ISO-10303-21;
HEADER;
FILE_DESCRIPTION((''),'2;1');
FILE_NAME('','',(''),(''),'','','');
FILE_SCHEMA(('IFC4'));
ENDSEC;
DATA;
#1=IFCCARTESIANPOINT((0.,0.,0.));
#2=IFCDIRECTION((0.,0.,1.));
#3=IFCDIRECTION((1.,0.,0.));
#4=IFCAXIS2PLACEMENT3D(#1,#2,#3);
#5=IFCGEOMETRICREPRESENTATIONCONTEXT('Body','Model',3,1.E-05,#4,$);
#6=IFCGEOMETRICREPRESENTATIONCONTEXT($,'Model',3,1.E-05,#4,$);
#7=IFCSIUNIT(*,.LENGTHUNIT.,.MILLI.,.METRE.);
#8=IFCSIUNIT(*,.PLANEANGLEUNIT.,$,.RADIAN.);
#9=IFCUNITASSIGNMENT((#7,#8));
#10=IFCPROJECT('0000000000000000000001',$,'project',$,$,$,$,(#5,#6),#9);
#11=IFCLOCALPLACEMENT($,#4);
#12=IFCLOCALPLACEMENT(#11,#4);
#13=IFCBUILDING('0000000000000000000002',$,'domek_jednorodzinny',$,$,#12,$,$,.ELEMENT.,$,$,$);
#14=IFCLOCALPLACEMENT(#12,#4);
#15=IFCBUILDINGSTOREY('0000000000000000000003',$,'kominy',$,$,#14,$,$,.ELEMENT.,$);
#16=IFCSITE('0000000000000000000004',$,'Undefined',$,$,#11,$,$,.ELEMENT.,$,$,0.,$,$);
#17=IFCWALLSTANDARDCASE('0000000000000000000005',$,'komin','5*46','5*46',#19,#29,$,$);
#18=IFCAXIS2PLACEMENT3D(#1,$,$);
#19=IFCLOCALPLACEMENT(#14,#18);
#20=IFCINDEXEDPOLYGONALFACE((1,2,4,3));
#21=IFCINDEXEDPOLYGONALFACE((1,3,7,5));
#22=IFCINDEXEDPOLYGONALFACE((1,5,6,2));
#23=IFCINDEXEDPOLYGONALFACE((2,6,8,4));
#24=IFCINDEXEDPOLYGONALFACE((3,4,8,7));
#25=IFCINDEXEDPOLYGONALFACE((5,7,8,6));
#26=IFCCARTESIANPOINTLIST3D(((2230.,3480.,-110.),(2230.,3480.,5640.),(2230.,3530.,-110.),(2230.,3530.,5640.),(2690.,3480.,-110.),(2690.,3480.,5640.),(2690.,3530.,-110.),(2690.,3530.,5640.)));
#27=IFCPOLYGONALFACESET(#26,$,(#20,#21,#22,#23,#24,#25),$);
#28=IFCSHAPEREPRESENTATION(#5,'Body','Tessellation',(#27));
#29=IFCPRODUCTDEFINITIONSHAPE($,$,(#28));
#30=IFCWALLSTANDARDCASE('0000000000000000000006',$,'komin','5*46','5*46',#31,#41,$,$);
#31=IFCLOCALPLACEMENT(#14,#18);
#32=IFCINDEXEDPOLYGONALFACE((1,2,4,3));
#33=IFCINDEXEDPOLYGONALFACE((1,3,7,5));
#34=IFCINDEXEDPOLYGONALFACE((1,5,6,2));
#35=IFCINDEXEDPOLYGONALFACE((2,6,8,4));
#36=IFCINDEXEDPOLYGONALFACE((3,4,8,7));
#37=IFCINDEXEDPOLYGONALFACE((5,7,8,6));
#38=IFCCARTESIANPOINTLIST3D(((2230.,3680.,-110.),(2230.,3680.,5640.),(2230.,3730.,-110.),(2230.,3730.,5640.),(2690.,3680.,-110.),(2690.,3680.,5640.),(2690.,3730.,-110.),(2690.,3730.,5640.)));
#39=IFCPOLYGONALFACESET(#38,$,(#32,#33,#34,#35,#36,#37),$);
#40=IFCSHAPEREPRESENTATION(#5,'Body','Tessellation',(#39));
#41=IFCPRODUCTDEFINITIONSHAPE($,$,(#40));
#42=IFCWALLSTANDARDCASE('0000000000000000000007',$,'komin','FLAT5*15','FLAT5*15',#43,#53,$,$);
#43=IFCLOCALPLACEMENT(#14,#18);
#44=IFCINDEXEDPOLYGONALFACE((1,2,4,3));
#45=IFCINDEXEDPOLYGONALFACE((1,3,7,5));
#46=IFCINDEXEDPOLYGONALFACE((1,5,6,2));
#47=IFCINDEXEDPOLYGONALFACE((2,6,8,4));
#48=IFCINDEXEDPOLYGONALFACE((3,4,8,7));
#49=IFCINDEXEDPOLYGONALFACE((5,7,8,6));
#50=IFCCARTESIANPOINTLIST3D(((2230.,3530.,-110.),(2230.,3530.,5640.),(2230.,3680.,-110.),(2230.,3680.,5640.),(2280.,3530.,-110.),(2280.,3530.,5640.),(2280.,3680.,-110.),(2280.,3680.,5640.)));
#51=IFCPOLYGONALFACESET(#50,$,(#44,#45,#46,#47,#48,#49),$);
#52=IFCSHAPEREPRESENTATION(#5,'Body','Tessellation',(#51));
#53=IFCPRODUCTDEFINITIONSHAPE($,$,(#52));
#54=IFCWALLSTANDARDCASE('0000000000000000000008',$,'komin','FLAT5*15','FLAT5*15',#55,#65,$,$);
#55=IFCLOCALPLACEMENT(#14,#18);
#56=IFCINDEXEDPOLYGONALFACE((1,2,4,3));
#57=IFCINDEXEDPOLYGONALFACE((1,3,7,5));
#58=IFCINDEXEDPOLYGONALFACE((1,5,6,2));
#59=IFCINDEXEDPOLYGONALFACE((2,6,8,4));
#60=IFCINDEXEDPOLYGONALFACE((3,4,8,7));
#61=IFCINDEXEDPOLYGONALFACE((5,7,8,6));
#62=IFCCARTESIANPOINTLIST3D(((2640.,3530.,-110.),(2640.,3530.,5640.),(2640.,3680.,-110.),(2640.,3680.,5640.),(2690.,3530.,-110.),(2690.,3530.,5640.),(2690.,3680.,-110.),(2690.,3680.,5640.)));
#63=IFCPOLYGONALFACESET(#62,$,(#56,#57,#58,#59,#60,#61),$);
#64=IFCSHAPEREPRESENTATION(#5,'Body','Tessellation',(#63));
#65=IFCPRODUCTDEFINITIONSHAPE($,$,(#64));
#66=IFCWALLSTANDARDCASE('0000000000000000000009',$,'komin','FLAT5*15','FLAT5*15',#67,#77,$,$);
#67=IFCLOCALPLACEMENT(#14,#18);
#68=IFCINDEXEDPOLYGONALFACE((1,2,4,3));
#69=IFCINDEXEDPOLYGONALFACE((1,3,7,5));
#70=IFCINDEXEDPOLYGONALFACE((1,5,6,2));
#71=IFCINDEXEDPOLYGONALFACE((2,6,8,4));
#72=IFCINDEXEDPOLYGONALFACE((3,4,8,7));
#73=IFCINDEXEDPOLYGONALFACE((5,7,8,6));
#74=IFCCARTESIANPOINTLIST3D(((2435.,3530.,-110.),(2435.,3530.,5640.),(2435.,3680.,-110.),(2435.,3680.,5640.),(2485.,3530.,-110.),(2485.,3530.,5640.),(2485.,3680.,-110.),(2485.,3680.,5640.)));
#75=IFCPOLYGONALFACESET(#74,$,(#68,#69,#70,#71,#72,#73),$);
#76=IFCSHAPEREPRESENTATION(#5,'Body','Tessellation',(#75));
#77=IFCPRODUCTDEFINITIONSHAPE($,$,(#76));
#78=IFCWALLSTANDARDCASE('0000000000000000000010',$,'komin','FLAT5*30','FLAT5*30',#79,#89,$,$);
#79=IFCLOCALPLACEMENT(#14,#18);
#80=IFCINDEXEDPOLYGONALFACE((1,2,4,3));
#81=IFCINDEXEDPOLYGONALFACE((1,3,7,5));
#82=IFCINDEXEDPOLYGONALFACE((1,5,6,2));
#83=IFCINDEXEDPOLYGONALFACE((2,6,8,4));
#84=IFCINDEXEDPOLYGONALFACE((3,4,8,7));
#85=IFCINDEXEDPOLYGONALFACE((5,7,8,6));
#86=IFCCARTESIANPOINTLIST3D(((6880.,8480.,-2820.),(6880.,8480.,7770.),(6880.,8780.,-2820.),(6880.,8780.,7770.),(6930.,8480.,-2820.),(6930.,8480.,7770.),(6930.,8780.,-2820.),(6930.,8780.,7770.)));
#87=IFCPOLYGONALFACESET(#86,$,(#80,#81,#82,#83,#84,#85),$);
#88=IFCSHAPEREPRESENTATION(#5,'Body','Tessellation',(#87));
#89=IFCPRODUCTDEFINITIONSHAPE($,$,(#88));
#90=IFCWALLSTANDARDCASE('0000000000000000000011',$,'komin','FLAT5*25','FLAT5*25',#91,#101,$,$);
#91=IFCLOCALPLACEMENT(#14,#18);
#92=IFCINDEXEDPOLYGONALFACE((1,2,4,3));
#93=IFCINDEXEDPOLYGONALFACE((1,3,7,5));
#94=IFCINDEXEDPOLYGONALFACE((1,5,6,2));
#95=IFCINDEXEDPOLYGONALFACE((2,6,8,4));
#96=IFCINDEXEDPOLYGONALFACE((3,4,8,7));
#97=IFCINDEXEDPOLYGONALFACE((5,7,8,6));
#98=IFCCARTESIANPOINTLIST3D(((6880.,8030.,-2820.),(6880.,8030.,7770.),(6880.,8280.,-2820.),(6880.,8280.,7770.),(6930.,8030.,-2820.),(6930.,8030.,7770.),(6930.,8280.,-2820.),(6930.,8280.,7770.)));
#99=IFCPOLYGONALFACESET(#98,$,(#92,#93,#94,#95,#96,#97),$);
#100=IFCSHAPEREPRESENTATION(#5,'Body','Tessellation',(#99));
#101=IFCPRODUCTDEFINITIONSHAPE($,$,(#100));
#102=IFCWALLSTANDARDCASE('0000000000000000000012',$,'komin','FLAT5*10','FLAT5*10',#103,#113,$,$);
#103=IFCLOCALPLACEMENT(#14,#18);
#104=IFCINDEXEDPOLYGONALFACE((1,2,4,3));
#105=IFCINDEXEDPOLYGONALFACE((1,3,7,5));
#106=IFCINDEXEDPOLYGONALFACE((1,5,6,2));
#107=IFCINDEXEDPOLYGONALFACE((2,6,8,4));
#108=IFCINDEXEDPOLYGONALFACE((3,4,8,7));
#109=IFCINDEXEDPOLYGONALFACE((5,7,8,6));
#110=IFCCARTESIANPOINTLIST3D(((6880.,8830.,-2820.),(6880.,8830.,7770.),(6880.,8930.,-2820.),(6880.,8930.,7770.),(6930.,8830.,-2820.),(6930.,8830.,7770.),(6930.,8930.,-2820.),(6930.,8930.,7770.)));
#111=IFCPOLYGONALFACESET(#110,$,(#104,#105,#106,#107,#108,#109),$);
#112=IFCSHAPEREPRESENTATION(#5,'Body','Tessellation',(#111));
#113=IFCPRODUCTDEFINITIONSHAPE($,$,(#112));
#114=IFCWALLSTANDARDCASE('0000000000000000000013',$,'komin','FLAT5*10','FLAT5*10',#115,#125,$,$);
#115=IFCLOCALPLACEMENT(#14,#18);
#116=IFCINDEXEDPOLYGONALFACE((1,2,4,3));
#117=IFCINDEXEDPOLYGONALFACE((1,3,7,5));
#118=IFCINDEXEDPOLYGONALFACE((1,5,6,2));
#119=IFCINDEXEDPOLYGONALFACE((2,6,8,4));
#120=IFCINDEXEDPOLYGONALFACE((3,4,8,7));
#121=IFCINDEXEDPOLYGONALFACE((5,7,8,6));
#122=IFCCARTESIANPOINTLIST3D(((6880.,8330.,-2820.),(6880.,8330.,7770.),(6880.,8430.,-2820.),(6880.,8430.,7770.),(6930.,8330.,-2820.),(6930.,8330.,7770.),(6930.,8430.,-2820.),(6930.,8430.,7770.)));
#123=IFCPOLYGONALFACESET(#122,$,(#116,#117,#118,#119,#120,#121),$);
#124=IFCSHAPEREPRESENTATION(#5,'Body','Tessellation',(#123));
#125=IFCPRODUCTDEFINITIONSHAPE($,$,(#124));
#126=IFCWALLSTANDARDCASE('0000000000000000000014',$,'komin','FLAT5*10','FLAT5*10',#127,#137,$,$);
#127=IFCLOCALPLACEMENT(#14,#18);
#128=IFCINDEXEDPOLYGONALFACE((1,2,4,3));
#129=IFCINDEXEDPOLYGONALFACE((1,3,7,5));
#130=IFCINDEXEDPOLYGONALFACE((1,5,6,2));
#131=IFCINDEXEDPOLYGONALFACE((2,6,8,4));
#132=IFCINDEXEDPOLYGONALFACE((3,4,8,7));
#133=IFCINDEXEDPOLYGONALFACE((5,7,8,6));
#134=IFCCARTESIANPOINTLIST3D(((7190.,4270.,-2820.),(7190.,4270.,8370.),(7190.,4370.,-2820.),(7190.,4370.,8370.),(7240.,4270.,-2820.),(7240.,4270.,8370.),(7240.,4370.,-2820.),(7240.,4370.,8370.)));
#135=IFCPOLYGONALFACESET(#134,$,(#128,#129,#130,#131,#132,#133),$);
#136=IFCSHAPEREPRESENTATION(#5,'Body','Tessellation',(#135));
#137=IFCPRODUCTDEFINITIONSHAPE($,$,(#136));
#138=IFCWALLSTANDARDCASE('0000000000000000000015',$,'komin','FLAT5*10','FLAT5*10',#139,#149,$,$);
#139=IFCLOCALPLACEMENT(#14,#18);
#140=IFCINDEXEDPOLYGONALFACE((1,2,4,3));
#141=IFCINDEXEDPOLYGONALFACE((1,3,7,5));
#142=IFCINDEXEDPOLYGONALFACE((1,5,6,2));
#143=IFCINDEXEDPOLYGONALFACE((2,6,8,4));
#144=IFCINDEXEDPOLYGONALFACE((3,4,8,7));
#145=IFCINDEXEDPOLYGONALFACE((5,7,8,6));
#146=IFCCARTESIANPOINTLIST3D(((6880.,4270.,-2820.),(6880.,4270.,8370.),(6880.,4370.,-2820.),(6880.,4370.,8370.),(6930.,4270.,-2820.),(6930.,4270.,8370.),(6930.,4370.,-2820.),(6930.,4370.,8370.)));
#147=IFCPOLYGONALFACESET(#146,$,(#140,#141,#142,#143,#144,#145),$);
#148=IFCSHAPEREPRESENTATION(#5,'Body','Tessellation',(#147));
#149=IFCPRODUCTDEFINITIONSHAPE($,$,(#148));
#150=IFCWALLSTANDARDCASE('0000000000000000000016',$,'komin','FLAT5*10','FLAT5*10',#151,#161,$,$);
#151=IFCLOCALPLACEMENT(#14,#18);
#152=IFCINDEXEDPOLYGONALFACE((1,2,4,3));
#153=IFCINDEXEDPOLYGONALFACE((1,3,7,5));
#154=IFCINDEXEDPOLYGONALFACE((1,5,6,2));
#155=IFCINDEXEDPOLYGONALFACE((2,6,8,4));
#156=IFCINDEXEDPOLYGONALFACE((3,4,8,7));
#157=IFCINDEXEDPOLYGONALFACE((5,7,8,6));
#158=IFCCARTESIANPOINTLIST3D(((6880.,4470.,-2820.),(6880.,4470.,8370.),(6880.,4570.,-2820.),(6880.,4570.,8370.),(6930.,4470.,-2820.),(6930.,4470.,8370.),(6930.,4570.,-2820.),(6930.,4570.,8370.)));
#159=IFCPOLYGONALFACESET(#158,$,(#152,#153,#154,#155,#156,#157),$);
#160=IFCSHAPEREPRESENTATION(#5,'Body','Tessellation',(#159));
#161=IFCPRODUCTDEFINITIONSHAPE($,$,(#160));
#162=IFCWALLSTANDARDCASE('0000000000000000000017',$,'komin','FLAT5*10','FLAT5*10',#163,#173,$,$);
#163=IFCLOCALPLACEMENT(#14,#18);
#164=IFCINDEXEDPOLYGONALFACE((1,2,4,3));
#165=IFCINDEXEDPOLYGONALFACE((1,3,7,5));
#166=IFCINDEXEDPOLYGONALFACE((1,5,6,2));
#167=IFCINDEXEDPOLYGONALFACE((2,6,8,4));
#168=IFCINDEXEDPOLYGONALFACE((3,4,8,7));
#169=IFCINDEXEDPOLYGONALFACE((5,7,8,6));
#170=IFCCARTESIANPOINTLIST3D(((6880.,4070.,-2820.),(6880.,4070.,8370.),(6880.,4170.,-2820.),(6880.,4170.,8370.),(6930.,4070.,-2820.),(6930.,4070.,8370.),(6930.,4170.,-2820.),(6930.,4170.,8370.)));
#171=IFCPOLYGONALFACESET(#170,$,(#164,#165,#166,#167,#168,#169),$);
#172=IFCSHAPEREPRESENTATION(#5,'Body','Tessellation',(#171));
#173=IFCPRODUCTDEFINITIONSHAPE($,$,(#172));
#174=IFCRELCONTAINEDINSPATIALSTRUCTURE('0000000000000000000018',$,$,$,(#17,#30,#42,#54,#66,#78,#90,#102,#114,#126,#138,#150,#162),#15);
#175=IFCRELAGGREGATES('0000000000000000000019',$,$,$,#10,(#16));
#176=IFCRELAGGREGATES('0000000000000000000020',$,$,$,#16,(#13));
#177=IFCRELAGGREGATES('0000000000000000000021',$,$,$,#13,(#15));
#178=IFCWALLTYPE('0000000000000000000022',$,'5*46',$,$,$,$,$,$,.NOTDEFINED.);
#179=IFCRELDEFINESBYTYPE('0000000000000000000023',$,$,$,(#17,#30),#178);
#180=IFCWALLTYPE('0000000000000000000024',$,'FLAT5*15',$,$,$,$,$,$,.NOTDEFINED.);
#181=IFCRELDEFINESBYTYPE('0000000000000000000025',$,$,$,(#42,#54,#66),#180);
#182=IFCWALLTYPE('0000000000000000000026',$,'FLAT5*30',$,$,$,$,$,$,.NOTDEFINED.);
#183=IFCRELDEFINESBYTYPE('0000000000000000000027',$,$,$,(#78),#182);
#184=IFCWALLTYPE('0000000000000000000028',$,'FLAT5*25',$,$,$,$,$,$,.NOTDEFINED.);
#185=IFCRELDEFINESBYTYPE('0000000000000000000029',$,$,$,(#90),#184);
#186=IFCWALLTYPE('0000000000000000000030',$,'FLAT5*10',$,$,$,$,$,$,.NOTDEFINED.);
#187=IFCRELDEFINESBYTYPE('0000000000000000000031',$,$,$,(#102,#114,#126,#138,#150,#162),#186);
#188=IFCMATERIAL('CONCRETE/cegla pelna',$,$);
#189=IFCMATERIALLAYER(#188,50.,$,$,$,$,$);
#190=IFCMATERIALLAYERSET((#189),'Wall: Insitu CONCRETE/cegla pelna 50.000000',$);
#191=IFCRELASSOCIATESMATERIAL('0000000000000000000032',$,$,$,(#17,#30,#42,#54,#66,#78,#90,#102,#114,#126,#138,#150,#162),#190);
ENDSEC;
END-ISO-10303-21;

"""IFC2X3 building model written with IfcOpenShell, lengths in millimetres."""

from ifc_helpers import new_model, si_unit, frame, frame_2d, origin_with_axes, place, context, project, spatial, rectangle, extrude, material, layer, layer_set, layer_usage, type_object, element, save


model = new_model("IFC2X3")

# Units and contexts
model_context_1 = context("Model", 3, precision=1e-05, world=origin_with_axes(), identifier="Body")
model_context_2 = context("Model", 3, precision=1e-05, world=origin_with_axes())
ifc_project = project(units=[si_unit("LENGTHUNIT", "METRE", prefix="MILLI"), si_unit("PLANEANGLEUNIT", "RADIAN")], contexts=[model_context_1, model_context_2])

# Site, building, storey
site_placement = place(None, origin_with_axes())
site = spatial("IfcSite", under=ifc_project, at=site_placement, Name="Undefined", CompositionType="ELEMENT", RefElevation=0.0)
building_placement = place(site_placement, origin_with_axes())
building = spatial("IfcBuilding", under=site, at=building_placement, Name="domek_jednorodzinny", CompositionType="ELEMENT")
storey_placement = place(building_placement, origin_with_axes())
storey = spatial("IfcBuildingStorey", under=building, at=storey_placement, Name="kominy", CompositionType="ELEMENT")

# Walls
ifc_material = material(Name="CONCRETE/cegla pelna")
ifc_layer = layer(ifc_material, 50.0)
ifc_layer_set = layer_set([ifc_layer], Name="Wall: Insitu CONCRETE/cegla pelna 50.000000")
ifc_layer_usage_1 = layer_usage(ifc_layer_set, "AXIS2", "POSITIVE", -25.0)
wall_type_1 = type_object("IfcWallType", Name="5*46", PredefinedType="NOTDEFINED")
wall_1_placement = place(storey_placement, frame((2230.0, 3505.0, -110.0), z_axis=(0.0, 0.0, 1.0), x_axis=(1.0, 0.0, 0.0)))
element("IfcWallStandardCase", 1, at=wall_1_placement, inside=storey, type_object=wall_type_1, material=ifc_layer_usage_1, Name="komin", Description="5*46", ObjectType="5*46", context=model_context_1, shape_type="SweptSolid", body=[
    extrude(rectangle(XDim=460.0, YDim=50.0, at=frame_2d((0.0, 230.0), x_axis=(0.0, -1.0))), frame((0.0, 0.0, 0.0), z_axis=(0.0, 0.0, 1.0), x_axis=(0.0, -1.0, 0.0)), (0.0, 0.0, 1.0), 5750.0),
])
ifc_layer_usage_2 = layer_usage(ifc_layer_set, "AXIS2", "POSITIVE", -25.0)
wall_2_placement = place(storey_placement, frame((2230.0, 3705.0, -110.0), z_axis=(0.0, 0.0, 1.0), x_axis=(1.0, 0.0, 0.0)))
element("IfcWallStandardCase", 2, at=wall_2_placement, inside=storey, type_object=wall_type_1, material=ifc_layer_usage_2, Name="komin", Description="5*46", ObjectType="5*46", context=model_context_1, shape_type="SweptSolid", body=[
    extrude(rectangle(XDim=460.0, YDim=50.0, at=frame_2d((0.0, 230.0), x_axis=(0.0, -1.0))), frame((0.0, 0.0, 0.0), z_axis=(0.0, 0.0, 1.0), x_axis=(0.0, -1.0, 0.0)), (0.0, 0.0, 1.0), 5750.0),
])
ifc_layer_usage_3 = layer_usage(ifc_layer_set, "AXIS2", "POSITIVE", -25.0)
wall_type_2 = type_object("IfcWallType", Name="FLAT5*15", PredefinedType="NOTDEFINED")
wall_3_placement = place(storey_placement, frame((2255.0, 3530.0, -110.0), z_axis=(0.0, 0.0, 1.0), x_axis=(0.0, 1.0, 0.0)))
element("IfcWallStandardCase", 3, at=wall_3_placement, inside=storey, type_object=wall_type_2, material=ifc_layer_usage_3, Name="komin", Description="FLAT5*15", ObjectType="FLAT5*15", context=model_context_1, shape_type="SweptSolid", body=[
    extrude(rectangle(XDim=150.0, YDim=50.0, at=frame_2d((0.0, 75.0), x_axis=(0.0, -1.0))), frame((0.0, 0.0, 0.0), z_axis=(0.0, 0.0, 1.0), x_axis=(0.0, -1.0, 0.0)), (0.0, 0.0, 1.0), 5750.0),
])
ifc_layer_usage_4 = layer_usage(ifc_layer_set, "AXIS2", "POSITIVE", -25.0)
wall_4_placement = place(storey_placement, frame((2665.0, 3530.0, -110.0), z_axis=(0.0, 0.0, 1.0), x_axis=(0.0, 1.0, 0.0)))
element("IfcWallStandardCase", 4, at=wall_4_placement, inside=storey, type_object=wall_type_2, material=ifc_layer_usage_4, Name="komin", Description="FLAT5*15", ObjectType="FLAT5*15", context=model_context_1, shape_type="SweptSolid", body=[
    extrude(rectangle(XDim=150.0, YDim=50.0, at=frame_2d((0.0, 75.0), x_axis=(0.0, -1.0))), frame((0.0, 0.0, 0.0), z_axis=(0.0, 0.0, 1.0), x_axis=(0.0, -1.0, 0.0)), (0.0, 0.0, 1.0), 5750.0),
])
ifc_layer_usage_5 = layer_usage(ifc_layer_set, "AXIS2", "POSITIVE", -25.0)
wall_5_placement = place(storey_placement, frame((2460.0, 3530.0, -110.0), z_axis=(0.0, 0.0, 1.0), x_axis=(0.0, 1.0, 0.0)))
element("IfcWallStandardCase", 5, at=wall_5_placement, inside=storey, type_object=wall_type_2, material=ifc_layer_usage_5, Name="komin", Description="FLAT5*15", ObjectType="FLAT5*15", context=model_context_1, shape_type="SweptSolid", body=[
    extrude(rectangle(XDim=150.0, YDim=50.0, at=frame_2d((0.0, 75.0), x_axis=(0.0, -1.0))), frame((0.0, 0.0, 0.0), z_axis=(0.0, 0.0, 1.0), x_axis=(0.0, -1.0, 0.0)), (0.0, 0.0, 1.0), 5750.0),
])
ifc_layer_usage_6 = layer_usage(ifc_layer_set, "AXIS2", "POSITIVE", -25.0)
wall_type_3 = type_object("IfcWallType", Name="FLAT5*30", PredefinedType="NOTDEFINED")
wall_6_placement = place(storey_placement, frame((6905.0, 8480.0, -2820.0), z_axis=(0.0, 0.0, 1.0), x_axis=(0.0, 1.0, 0.0)))
element("IfcWallStandardCase", 6, at=wall_6_placement, inside=storey, type_object=wall_type_3, material=ifc_layer_usage_6, Name="komin", Description="FLAT5*30", ObjectType="FLAT5*30", context=model_context_1, shape_type="SweptSolid", body=[
    extrude(rectangle(XDim=300.0, YDim=50.0, at=frame_2d((0.0, 150.0), x_axis=(0.0, -1.0))), frame((0.0, 0.0, 0.0), z_axis=(0.0, 0.0, 1.0), x_axis=(0.0, -1.0, 0.0)), (0.0, 0.0, 1.0), 10590.0),
])
ifc_layer_usage_7 = layer_usage(ifc_layer_set, "AXIS2", "POSITIVE", -25.0)
wall_type_4 = type_object("IfcWallType", Name="FLAT5*25", PredefinedType="NOTDEFINED")
wall_7_placement = place(storey_placement, frame((6905.0, 8030.0, -2820.0), z_axis=(0.0, 0.0, 1.0), x_axis=(0.0, 1.0, 0.0)))
element("IfcWallStandardCase", 7, at=wall_7_placement, inside=storey, type_object=wall_type_4, material=ifc_layer_usage_7, Name="komin", Description="FLAT5*25", ObjectType="FLAT5*25", context=model_context_1, shape_type="SweptSolid", body=[
    extrude(rectangle(XDim=250.0, YDim=50.0, at=frame_2d((0.0, 125.0), x_axis=(0.0, -1.0))), frame((0.0, 0.0, 0.0), z_axis=(0.0, 0.0, 1.0), x_axis=(0.0, -1.0, 0.0)), (0.0, 0.0, 1.0), 10590.0),
])
ifc_layer_usage_8 = layer_usage(ifc_layer_set, "AXIS2", "POSITIVE", -25.0)
wall_type_5 = type_object("IfcWallType", Name="FLAT5*10", PredefinedType="NOTDEFINED")
wall_8_placement = place(storey_placement, frame((6905.0, 8830.0, -2820.0), z_axis=(0.0, 0.0, 1.0), x_axis=(0.0, 1.0, 0.0)))
element("IfcWallStandardCase", 8, at=wall_8_placement, inside=storey, type_object=wall_type_5, material=ifc_layer_usage_8, Name="komin", Description="FLAT5*10", ObjectType="FLAT5*10", context=model_context_1, shape_type="SweptSolid", body=[
    extrude(rectangle(XDim=100.0, YDim=50.0, at=frame_2d((0.0, 50.0), x_axis=(0.0, -1.0))), frame((0.0, 0.0, 0.0), z_axis=(0.0, 0.0, 1.0), x_axis=(0.0, -1.0, 0.0)), (0.0, 0.0, 1.0), 10590.0),
])
ifc_layer_usage_9 = layer_usage(ifc_layer_set, "AXIS2", "POSITIVE", -25.0)
wall_9_placement = place(storey_placement, frame((6905.0, 8330.0, -2820.0), z_axis=(0.0, 0.0, 1.0), x_axis=(0.0, 1.0, 0.0)))
element("IfcWallStandardCase", 9, at=wall_9_placement, inside=storey, type_object=wall_type_5, material=ifc_layer_usage_9, Name="komin", Description="FLAT5*10", ObjectType="FLAT5*10", context=model_context_1, shape_type="SweptSolid", body=[
    extrude(rectangle(XDim=100.0, YDim=50.0, at=frame_2d((0.0, 50.0), x_axis=(0.0, -1.0))), frame((0.0, 0.0, 0.0), z_axis=(0.0, 0.0, 1.0), x_axis=(0.0, -1.0, 0.0)), (0.0, 0.0, 1.0), 10590.0),
])
ifc_layer_usage_10 = layer_usage(ifc_layer_set, "AXIS2", "POSITIVE", -25.0)
wall_10_placement = place(storey_placement, frame((7215.0, 4270.0, -2820.0), z_axis=(0.0, 0.0, 1.0), x_axis=(0.0, 1.0, 0.0)))
element("IfcWallStandardCase", 10, at=wall_10_placement, inside=storey, type_object=wall_type_5, material=ifc_layer_usage_10, Name="komin", Description="FLAT5*10", ObjectType="FLAT5*10", context=model_context_1, shape_type="SweptSolid", body=[
    extrude(rectangle(XDim=100.0, YDim=50.0, at=frame_2d((0.0, 50.0), x_axis=(0.0, -1.0))), frame((0.0, 0.0, 0.0), z_axis=(0.0, 0.0, 1.0), x_axis=(0.0, -1.0, 0.0)), (0.0, 0.0, 1.0), 11190.0),
])
ifc_layer_usage_11 = layer_usage(ifc_layer_set, "AXIS2", "POSITIVE", -25.0)
wall_11_placement = place(storey_placement, frame((6905.0, 4270.0, -2820.0), z_axis=(0.0, 0.0, 1.0), x_axis=(0.0, 1.0, 0.0)))
element("IfcWallStandardCase", 11, at=wall_11_placement, inside=storey, type_object=wall_type_5, material=ifc_layer_usage_11, Name="komin", Description="FLAT5*10", ObjectType="FLAT5*10", context=model_context_1, shape_type="SweptSolid", body=[
    extrude(rectangle(XDim=100.0, YDim=50.0, at=frame_2d((0.0, 50.0), x_axis=(0.0, -1.0))), frame((0.0, 0.0, 0.0), z_axis=(0.0, 0.0, 1.0), x_axis=(0.0, -1.0, 0.0)), (0.0, 0.0, 1.0), 11190.0),
])
ifc_layer_usage_12 = layer_usage(ifc_layer_set, "AXIS2", "POSITIVE", -25.0)
wall_12_placement = place(storey_placement, frame((6905.0, 4470.0, -2820.0), z_axis=(0.0, 0.0, 1.0), x_axis=(0.0, 1.0, 0.0)))
element("IfcWallStandardCase", 12, at=wall_12_placement, inside=storey, type_object=wall_type_5, material=ifc_layer_usage_12, Name="komin", Description="FLAT5*10", ObjectType="FLAT5*10", context=model_context_1, shape_type="SweptSolid", body=[
    extrude(rectangle(XDim=100.0, YDim=50.0, at=frame_2d((0.0, 50.0), x_axis=(0.0, -1.0))), frame((0.0, 0.0, 0.0), z_axis=(0.0, 0.0, 1.0), x_axis=(0.0, -1.0, 0.0)), (0.0, 0.0, 1.0), 11190.0),
])
ifc_layer_usage_13 = layer_usage(ifc_layer_set, "AXIS2", "POSITIVE", -25.0)
wall_13_placement = place(storey_placement, frame((6905.0, 4070.0, -2820.0), z_axis=(0.0, 0.0, 1.0), x_axis=(0.0, 1.0, 0.0)))
element("IfcWallStandardCase", 13, at=wall_13_placement, inside=storey, type_object=wall_type_5, material=ifc_layer_usage_13, Name="komin", Description="FLAT5*10", ObjectType="FLAT5*10", context=model_context_1, shape_type="SweptSolid", body=[
    extrude(rectangle(XDim=100.0, YDim=50.0, at=frame_2d((0.0, 50.0), x_axis=(0.0, -1.0))), frame((0.0, 0.0, 0.0), z_axis=(0.0, 0.0, 1.0), x_axis=(0.0, -1.0, 0.0)), (0.0, 0.0, 1.0), 11190.0),
])

save(model, "model.ifc")
